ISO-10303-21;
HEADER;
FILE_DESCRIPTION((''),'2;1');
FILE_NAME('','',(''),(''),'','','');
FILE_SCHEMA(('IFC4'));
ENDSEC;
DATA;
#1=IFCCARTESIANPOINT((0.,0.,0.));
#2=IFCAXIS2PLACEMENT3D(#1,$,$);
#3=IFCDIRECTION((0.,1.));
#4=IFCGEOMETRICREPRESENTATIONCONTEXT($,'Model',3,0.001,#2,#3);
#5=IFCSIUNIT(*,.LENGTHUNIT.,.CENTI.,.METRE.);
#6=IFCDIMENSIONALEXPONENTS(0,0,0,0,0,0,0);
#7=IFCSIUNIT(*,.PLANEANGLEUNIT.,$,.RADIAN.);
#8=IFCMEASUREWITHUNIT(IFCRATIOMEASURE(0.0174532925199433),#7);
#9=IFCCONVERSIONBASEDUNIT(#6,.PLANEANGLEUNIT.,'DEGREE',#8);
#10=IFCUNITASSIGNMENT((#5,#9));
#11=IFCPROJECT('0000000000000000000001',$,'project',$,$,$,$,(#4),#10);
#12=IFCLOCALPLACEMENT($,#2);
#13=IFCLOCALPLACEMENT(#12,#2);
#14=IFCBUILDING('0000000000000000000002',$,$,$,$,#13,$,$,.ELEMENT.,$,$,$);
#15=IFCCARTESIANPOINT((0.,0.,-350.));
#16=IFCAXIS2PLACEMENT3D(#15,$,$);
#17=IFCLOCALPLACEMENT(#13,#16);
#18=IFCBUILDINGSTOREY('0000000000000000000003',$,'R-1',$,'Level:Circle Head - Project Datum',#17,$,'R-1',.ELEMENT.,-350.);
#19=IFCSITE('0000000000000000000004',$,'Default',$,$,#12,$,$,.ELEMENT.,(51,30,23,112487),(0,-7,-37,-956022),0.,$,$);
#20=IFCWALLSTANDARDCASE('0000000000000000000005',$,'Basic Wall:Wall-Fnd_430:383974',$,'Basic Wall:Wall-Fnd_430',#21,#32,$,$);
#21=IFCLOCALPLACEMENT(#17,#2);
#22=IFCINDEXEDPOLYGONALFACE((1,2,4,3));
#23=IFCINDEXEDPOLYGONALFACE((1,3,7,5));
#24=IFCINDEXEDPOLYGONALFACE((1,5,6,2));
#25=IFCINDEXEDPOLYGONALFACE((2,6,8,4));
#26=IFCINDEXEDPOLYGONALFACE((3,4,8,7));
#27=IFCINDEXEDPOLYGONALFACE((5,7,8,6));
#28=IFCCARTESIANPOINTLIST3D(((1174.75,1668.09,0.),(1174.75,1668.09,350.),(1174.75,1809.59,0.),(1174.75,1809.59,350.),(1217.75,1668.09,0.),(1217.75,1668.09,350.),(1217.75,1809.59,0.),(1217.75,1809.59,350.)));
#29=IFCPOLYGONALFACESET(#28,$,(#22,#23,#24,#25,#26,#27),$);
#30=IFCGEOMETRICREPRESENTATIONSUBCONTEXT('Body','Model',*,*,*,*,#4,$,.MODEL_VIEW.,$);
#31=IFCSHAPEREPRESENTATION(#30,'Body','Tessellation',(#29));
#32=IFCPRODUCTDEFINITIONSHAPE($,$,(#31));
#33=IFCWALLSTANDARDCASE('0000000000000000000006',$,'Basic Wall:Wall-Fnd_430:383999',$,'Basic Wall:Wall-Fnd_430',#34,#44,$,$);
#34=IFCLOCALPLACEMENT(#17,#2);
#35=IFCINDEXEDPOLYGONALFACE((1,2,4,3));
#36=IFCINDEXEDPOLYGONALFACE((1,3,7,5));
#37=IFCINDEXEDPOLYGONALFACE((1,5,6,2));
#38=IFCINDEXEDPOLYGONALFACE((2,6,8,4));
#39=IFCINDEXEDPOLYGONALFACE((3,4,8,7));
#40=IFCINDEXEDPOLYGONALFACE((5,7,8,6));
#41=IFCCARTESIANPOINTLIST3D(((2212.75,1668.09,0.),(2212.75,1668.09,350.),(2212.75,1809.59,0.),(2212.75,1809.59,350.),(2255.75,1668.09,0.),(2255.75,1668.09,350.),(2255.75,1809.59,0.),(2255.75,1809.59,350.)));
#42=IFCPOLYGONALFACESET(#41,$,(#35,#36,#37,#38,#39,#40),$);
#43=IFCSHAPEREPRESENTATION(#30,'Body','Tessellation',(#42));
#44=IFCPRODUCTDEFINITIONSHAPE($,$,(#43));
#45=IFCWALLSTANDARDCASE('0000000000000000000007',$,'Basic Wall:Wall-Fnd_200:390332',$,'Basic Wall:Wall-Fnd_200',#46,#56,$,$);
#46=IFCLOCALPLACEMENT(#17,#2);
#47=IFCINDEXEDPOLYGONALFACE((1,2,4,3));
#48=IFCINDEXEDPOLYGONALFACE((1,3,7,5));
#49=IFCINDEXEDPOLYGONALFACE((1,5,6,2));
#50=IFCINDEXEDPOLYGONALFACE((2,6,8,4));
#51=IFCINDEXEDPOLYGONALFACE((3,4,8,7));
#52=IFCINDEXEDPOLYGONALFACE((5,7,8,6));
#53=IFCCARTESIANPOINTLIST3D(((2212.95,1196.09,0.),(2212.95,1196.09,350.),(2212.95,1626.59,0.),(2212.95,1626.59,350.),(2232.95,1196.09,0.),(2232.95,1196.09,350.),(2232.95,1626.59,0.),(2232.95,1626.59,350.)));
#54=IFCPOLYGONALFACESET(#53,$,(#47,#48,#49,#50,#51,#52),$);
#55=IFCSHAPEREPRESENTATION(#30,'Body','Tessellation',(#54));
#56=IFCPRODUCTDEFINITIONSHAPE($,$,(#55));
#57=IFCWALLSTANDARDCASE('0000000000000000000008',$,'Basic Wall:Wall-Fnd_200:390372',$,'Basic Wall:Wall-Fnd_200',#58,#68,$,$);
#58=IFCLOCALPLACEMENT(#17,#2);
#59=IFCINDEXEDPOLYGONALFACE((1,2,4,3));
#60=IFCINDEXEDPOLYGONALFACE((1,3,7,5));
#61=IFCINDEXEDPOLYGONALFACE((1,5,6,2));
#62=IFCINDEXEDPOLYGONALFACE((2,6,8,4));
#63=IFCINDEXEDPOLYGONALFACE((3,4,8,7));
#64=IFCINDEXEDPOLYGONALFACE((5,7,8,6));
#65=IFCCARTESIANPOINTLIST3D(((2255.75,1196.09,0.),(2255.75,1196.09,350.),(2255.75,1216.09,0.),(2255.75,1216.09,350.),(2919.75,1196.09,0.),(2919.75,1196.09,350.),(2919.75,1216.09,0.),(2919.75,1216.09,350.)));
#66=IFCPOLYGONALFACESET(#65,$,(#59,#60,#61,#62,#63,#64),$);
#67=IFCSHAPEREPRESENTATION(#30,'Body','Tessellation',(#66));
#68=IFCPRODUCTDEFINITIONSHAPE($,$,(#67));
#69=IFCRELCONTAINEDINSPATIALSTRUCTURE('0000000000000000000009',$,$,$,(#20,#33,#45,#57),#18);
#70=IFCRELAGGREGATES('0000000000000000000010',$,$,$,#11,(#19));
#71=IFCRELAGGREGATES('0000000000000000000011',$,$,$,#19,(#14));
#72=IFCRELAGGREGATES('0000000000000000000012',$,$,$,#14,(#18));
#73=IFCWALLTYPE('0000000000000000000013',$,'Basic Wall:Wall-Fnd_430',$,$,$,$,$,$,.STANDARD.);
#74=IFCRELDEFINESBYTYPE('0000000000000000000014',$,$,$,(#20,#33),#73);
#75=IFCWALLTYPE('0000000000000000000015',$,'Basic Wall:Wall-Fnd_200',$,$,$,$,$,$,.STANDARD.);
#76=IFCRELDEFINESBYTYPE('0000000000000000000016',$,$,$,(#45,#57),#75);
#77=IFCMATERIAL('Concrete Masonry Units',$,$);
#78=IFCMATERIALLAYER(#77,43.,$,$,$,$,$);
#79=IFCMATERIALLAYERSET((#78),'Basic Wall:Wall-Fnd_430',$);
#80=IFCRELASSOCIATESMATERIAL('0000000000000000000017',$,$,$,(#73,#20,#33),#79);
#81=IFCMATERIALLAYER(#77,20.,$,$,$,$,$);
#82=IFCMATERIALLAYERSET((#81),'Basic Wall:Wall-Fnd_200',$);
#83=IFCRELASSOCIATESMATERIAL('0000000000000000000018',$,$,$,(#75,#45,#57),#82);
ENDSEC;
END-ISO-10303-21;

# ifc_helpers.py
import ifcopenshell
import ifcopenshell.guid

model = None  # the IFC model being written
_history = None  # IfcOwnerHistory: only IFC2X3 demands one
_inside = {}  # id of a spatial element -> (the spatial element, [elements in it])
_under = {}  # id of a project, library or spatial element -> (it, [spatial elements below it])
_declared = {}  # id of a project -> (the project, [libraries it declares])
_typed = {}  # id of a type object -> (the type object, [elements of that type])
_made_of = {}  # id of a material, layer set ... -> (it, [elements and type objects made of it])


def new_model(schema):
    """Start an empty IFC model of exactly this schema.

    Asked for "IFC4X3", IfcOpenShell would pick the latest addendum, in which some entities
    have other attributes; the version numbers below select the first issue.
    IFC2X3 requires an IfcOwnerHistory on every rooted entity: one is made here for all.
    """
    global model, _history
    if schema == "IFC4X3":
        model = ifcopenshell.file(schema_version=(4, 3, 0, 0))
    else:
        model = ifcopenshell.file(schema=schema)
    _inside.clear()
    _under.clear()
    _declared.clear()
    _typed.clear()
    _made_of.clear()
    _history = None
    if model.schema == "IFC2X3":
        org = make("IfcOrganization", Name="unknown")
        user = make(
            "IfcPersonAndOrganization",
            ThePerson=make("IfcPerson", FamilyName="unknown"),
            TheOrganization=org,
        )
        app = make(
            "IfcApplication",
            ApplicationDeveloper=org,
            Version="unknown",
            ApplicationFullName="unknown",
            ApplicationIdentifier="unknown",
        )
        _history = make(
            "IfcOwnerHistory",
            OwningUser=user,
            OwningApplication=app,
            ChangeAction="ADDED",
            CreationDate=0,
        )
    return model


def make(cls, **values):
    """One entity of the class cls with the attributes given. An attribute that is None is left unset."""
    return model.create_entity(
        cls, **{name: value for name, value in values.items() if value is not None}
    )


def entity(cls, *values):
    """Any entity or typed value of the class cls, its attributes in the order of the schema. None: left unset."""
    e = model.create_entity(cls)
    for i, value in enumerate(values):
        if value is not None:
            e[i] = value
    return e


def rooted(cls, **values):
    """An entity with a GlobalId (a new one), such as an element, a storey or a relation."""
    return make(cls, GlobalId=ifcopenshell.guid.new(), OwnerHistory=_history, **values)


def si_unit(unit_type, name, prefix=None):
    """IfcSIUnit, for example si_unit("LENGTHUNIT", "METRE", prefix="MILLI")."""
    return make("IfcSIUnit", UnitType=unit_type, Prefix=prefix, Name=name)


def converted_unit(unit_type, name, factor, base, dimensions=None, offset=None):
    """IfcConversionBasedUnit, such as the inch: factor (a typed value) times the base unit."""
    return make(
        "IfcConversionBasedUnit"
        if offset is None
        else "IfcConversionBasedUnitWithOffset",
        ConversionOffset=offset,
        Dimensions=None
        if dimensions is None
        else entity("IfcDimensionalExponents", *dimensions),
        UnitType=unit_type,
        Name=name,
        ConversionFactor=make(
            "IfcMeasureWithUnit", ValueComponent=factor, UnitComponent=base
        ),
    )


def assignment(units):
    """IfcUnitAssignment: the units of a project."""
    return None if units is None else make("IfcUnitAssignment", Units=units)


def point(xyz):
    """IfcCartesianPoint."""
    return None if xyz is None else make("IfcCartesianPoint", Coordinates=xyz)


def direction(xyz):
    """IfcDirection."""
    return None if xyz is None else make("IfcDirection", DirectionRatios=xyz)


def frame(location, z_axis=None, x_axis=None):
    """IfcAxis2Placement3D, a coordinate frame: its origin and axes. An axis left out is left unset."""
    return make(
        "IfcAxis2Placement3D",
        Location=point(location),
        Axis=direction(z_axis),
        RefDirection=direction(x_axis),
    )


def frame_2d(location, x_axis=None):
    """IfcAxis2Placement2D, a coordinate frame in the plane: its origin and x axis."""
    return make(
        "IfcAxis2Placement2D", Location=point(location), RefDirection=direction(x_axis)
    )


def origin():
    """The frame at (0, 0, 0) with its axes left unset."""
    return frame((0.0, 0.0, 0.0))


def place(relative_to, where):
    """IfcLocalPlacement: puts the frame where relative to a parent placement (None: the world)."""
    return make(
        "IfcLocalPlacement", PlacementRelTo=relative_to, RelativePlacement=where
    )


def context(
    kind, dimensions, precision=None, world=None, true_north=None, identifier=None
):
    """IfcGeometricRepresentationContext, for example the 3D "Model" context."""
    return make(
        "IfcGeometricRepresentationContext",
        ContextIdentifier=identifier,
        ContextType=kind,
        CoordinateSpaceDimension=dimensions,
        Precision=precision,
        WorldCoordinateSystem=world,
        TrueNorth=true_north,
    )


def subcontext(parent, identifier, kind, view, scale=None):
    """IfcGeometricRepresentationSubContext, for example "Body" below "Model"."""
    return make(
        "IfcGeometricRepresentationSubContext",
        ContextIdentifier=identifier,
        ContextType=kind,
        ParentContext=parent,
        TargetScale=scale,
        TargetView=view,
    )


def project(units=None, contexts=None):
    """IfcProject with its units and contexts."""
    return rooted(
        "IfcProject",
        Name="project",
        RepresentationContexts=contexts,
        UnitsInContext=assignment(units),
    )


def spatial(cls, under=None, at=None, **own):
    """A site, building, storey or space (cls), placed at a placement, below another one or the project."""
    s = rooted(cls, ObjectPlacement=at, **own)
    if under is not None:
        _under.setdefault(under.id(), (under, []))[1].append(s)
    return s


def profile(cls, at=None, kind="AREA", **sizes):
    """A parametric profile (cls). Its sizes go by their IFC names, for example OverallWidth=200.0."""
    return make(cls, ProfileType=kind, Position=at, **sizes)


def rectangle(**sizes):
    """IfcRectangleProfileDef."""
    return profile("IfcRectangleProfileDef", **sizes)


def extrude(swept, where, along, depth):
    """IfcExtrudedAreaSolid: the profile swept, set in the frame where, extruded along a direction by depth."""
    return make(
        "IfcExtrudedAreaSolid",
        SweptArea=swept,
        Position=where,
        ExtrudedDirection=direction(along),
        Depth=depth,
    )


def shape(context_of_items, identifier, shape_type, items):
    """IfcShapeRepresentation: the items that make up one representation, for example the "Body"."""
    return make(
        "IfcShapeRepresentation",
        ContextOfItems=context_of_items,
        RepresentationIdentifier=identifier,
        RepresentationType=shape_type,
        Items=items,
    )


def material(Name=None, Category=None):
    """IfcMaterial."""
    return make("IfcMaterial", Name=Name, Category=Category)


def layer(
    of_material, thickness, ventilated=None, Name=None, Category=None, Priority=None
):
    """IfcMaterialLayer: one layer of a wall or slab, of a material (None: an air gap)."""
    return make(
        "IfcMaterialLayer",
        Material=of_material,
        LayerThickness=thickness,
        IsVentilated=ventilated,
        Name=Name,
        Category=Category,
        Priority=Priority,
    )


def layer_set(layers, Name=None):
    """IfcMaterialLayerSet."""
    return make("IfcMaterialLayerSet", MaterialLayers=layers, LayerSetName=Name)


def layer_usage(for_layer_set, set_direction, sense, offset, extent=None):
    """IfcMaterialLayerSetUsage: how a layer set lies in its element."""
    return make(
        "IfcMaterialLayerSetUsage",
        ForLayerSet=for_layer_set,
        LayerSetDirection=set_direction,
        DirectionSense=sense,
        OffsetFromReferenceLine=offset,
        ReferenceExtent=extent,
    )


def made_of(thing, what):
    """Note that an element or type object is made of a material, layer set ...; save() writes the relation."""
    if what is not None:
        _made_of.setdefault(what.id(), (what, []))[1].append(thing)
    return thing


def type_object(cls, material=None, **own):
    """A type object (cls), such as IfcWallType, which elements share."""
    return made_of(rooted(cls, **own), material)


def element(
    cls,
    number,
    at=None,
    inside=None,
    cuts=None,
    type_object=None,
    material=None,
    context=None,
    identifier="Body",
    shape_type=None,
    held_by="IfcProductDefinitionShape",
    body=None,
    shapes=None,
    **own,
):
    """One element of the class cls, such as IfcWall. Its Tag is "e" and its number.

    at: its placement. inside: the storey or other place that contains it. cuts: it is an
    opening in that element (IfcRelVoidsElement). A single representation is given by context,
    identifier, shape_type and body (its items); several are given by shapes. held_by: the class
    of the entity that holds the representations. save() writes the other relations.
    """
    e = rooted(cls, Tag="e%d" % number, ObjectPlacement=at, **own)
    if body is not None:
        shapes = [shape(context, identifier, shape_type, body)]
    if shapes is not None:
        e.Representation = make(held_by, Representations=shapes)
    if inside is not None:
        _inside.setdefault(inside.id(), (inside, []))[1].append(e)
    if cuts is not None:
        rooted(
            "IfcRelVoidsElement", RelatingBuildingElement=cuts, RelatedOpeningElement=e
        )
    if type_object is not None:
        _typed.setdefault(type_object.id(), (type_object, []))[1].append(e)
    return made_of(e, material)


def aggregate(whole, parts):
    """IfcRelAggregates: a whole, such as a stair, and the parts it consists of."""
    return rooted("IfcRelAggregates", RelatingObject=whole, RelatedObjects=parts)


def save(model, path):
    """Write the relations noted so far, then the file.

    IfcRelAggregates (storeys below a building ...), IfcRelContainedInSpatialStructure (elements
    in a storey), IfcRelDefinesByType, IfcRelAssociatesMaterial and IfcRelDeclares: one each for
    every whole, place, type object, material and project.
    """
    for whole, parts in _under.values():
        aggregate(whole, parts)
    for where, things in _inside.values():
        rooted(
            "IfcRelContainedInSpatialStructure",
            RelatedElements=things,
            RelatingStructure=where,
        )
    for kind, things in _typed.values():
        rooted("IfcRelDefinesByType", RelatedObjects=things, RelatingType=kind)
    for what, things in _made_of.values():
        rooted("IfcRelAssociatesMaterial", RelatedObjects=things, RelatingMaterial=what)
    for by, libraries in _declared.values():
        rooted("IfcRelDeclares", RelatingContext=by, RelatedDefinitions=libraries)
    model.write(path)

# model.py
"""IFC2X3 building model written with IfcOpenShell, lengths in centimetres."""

from ifc_helpers import new_model, entity, si_unit, converted_unit, direction, frame, frame_2d, origin, place, context, subcontext, project, spatial, rectangle, extrude, material, layer, layer_set, layer_usage, type_object, element, save


model = new_model("IFC2X3")

# Units and contexts
model_context = context("Model", 3, precision=0.001, world=origin(), true_north=direction((0.0, 1.0)))
body_context = subcontext(model_context, "Body", "Model", "MODEL_VIEW")
ifc_project = project(units=[si_unit("LENGTHUNIT", "METRE", prefix="CENTI"), converted_unit("PLANEANGLEUNIT", "DEGREE", entity("IfcRatioMeasure", 0.0174532925199433), si_unit("PLANEANGLEUNIT", "RADIAN"), dimensions=[0, 0, 0, 0, 0, 0, 0])], contexts=[model_context])

# Site, building, storey
site_placement = place(None, origin())
site = spatial("IfcSite", under=ifc_project, at=site_placement, Name="Default", CompositionType="ELEMENT", RefLatitude=(51, 30, 23, 112487), RefLongitude=(0, -7, -37, -956022), RefElevation=0.0)
building_placement = place(site_placement, origin())
building = spatial("IfcBuilding", under=site, at=building_placement, CompositionType="ELEMENT")
storey_placement = place(building_placement, frame((0.0, 0.0, -350.0)))
storey = spatial("IfcBuildingStorey", under=building, at=storey_placement, Name="R-1", ObjectType="Level:Circle Head - Project Datum", LongName="R-1", CompositionType="ELEMENT", Elevation=-350.0)

# Walls
ifc_material_1 = material(Name="Concrete Masonry Units")
ifc_layer_1 = layer(ifc_material_1, 43.0)
ifc_layer_set_1 = layer_set([ifc_layer_1], Name="Basic Wall:Wall-Fnd_430")
ifc_layer_usage_1 = layer_usage(ifc_layer_set_1, "AXIS2", "NEGATIVE", 21.5)
wall_type_1 = type_object("IfcWallType", Name="Basic Wall:Wall-Fnd_430", PredefinedType="STANDARD", material=ifc_layer_set_1)
wall_1_placement = place(storey_placement, frame((1196.25, 1668.09, 0.0), z_axis=(0.0, 0.0, 1.0), x_axis=(0.0, 1.0, 0.0)))
element("IfcWallStandardCase", 1, at=wall_1_placement, inside=storey, type_object=wall_type_1, material=ifc_layer_usage_1, Name="Basic Wall:Wall-Fnd_430:383974", ObjectType="Basic Wall:Wall-Fnd_430", context=body_context, shape_type="SweptSolid", body=[
    extrude(rectangle(XDim=141.5, YDim=43.0, at=frame_2d((70.75, 0.0), x_axis=(-1.0, 0.0))), origin(), (0.0, 0.0, 1.0), 350.0),
])
ifc_layer_usage_2 = layer_usage(ifc_layer_set_1, "AXIS2", "NEGATIVE", 21.5)
wall_2_placement = place(storey_placement, frame((2234.25, 1809.59, 0.0), z_axis=(0.0, 0.0, 1.0), x_axis=(0.0, -1.0, 0.0)))
element("IfcWallStandardCase", 2, at=wall_2_placement, inside=storey, type_object=wall_type_1, material=ifc_layer_usage_2, Name="Basic Wall:Wall-Fnd_430:383999", ObjectType="Basic Wall:Wall-Fnd_430", context=body_context, shape_type="SweptSolid", body=[
    extrude(rectangle(XDim=141.5, YDim=43.0, at=frame_2d((70.75, 0.0), x_axis=(-1.0, 0.0))), origin(), (0.0, 0.0, 1.0), 350.0),
])
ifc_layer_2 = layer(ifc_material_1, 20.0)
ifc_layer_set_2 = layer_set([ifc_layer_2], Name="Basic Wall:Wall-Fnd_200")
ifc_layer_usage_3 = layer_usage(ifc_layer_set_2, "AXIS2", "POSITIVE", -10.0)
wall_type_2 = type_object("IfcWallType", Name="Basic Wall:Wall-Fnd_200", PredefinedType="STANDARD", material=ifc_layer_set_2)
wall_3_placement = place(storey_placement, frame((2222.95, 1626.59, 0.0), z_axis=(0.0, 0.0, 1.0), x_axis=(0.0, -1.0, 0.0)))
element("IfcWallStandardCase", 3, at=wall_3_placement, inside=storey, type_object=wall_type_2, material=ifc_layer_usage_3, Name="Basic Wall:Wall-Fnd_200:390332", ObjectType="Basic Wall:Wall-Fnd_200", context=body_context, shape_type="SweptSolid", body=[
    extrude(rectangle(XDim=430.5, YDim=20.0, at=frame_2d((215.25, 0.0), x_axis=(-1.0, 0.0))), origin(), (0.0, 0.0, 1.0), 350.0),
])
ifc_layer_usage_4 = layer_usage(ifc_layer_set_2, "AXIS2", "POSITIVE", -10.0)
wall_4_placement = place(storey_placement, frame((2255.75, 1206.09, 0.0)))
element("IfcWallStandardCase", 4, at=wall_4_placement, inside=storey, type_object=wall_type_2, material=ifc_layer_usage_4, Name="Basic Wall:Wall-Fnd_200:390372", ObjectType="Basic Wall:Wall-Fnd_200", context=body_context, shape_type="SweptSolid", body=[
    extrude(rectangle(XDim=664.0, YDim=20.0, at=frame_2d((332.0, 0.0), x_axis=(-1.0, 0.0))), origin(), (0.0, 0.0, 1.0), 350.0),
])

save(model, "model.ifc")
